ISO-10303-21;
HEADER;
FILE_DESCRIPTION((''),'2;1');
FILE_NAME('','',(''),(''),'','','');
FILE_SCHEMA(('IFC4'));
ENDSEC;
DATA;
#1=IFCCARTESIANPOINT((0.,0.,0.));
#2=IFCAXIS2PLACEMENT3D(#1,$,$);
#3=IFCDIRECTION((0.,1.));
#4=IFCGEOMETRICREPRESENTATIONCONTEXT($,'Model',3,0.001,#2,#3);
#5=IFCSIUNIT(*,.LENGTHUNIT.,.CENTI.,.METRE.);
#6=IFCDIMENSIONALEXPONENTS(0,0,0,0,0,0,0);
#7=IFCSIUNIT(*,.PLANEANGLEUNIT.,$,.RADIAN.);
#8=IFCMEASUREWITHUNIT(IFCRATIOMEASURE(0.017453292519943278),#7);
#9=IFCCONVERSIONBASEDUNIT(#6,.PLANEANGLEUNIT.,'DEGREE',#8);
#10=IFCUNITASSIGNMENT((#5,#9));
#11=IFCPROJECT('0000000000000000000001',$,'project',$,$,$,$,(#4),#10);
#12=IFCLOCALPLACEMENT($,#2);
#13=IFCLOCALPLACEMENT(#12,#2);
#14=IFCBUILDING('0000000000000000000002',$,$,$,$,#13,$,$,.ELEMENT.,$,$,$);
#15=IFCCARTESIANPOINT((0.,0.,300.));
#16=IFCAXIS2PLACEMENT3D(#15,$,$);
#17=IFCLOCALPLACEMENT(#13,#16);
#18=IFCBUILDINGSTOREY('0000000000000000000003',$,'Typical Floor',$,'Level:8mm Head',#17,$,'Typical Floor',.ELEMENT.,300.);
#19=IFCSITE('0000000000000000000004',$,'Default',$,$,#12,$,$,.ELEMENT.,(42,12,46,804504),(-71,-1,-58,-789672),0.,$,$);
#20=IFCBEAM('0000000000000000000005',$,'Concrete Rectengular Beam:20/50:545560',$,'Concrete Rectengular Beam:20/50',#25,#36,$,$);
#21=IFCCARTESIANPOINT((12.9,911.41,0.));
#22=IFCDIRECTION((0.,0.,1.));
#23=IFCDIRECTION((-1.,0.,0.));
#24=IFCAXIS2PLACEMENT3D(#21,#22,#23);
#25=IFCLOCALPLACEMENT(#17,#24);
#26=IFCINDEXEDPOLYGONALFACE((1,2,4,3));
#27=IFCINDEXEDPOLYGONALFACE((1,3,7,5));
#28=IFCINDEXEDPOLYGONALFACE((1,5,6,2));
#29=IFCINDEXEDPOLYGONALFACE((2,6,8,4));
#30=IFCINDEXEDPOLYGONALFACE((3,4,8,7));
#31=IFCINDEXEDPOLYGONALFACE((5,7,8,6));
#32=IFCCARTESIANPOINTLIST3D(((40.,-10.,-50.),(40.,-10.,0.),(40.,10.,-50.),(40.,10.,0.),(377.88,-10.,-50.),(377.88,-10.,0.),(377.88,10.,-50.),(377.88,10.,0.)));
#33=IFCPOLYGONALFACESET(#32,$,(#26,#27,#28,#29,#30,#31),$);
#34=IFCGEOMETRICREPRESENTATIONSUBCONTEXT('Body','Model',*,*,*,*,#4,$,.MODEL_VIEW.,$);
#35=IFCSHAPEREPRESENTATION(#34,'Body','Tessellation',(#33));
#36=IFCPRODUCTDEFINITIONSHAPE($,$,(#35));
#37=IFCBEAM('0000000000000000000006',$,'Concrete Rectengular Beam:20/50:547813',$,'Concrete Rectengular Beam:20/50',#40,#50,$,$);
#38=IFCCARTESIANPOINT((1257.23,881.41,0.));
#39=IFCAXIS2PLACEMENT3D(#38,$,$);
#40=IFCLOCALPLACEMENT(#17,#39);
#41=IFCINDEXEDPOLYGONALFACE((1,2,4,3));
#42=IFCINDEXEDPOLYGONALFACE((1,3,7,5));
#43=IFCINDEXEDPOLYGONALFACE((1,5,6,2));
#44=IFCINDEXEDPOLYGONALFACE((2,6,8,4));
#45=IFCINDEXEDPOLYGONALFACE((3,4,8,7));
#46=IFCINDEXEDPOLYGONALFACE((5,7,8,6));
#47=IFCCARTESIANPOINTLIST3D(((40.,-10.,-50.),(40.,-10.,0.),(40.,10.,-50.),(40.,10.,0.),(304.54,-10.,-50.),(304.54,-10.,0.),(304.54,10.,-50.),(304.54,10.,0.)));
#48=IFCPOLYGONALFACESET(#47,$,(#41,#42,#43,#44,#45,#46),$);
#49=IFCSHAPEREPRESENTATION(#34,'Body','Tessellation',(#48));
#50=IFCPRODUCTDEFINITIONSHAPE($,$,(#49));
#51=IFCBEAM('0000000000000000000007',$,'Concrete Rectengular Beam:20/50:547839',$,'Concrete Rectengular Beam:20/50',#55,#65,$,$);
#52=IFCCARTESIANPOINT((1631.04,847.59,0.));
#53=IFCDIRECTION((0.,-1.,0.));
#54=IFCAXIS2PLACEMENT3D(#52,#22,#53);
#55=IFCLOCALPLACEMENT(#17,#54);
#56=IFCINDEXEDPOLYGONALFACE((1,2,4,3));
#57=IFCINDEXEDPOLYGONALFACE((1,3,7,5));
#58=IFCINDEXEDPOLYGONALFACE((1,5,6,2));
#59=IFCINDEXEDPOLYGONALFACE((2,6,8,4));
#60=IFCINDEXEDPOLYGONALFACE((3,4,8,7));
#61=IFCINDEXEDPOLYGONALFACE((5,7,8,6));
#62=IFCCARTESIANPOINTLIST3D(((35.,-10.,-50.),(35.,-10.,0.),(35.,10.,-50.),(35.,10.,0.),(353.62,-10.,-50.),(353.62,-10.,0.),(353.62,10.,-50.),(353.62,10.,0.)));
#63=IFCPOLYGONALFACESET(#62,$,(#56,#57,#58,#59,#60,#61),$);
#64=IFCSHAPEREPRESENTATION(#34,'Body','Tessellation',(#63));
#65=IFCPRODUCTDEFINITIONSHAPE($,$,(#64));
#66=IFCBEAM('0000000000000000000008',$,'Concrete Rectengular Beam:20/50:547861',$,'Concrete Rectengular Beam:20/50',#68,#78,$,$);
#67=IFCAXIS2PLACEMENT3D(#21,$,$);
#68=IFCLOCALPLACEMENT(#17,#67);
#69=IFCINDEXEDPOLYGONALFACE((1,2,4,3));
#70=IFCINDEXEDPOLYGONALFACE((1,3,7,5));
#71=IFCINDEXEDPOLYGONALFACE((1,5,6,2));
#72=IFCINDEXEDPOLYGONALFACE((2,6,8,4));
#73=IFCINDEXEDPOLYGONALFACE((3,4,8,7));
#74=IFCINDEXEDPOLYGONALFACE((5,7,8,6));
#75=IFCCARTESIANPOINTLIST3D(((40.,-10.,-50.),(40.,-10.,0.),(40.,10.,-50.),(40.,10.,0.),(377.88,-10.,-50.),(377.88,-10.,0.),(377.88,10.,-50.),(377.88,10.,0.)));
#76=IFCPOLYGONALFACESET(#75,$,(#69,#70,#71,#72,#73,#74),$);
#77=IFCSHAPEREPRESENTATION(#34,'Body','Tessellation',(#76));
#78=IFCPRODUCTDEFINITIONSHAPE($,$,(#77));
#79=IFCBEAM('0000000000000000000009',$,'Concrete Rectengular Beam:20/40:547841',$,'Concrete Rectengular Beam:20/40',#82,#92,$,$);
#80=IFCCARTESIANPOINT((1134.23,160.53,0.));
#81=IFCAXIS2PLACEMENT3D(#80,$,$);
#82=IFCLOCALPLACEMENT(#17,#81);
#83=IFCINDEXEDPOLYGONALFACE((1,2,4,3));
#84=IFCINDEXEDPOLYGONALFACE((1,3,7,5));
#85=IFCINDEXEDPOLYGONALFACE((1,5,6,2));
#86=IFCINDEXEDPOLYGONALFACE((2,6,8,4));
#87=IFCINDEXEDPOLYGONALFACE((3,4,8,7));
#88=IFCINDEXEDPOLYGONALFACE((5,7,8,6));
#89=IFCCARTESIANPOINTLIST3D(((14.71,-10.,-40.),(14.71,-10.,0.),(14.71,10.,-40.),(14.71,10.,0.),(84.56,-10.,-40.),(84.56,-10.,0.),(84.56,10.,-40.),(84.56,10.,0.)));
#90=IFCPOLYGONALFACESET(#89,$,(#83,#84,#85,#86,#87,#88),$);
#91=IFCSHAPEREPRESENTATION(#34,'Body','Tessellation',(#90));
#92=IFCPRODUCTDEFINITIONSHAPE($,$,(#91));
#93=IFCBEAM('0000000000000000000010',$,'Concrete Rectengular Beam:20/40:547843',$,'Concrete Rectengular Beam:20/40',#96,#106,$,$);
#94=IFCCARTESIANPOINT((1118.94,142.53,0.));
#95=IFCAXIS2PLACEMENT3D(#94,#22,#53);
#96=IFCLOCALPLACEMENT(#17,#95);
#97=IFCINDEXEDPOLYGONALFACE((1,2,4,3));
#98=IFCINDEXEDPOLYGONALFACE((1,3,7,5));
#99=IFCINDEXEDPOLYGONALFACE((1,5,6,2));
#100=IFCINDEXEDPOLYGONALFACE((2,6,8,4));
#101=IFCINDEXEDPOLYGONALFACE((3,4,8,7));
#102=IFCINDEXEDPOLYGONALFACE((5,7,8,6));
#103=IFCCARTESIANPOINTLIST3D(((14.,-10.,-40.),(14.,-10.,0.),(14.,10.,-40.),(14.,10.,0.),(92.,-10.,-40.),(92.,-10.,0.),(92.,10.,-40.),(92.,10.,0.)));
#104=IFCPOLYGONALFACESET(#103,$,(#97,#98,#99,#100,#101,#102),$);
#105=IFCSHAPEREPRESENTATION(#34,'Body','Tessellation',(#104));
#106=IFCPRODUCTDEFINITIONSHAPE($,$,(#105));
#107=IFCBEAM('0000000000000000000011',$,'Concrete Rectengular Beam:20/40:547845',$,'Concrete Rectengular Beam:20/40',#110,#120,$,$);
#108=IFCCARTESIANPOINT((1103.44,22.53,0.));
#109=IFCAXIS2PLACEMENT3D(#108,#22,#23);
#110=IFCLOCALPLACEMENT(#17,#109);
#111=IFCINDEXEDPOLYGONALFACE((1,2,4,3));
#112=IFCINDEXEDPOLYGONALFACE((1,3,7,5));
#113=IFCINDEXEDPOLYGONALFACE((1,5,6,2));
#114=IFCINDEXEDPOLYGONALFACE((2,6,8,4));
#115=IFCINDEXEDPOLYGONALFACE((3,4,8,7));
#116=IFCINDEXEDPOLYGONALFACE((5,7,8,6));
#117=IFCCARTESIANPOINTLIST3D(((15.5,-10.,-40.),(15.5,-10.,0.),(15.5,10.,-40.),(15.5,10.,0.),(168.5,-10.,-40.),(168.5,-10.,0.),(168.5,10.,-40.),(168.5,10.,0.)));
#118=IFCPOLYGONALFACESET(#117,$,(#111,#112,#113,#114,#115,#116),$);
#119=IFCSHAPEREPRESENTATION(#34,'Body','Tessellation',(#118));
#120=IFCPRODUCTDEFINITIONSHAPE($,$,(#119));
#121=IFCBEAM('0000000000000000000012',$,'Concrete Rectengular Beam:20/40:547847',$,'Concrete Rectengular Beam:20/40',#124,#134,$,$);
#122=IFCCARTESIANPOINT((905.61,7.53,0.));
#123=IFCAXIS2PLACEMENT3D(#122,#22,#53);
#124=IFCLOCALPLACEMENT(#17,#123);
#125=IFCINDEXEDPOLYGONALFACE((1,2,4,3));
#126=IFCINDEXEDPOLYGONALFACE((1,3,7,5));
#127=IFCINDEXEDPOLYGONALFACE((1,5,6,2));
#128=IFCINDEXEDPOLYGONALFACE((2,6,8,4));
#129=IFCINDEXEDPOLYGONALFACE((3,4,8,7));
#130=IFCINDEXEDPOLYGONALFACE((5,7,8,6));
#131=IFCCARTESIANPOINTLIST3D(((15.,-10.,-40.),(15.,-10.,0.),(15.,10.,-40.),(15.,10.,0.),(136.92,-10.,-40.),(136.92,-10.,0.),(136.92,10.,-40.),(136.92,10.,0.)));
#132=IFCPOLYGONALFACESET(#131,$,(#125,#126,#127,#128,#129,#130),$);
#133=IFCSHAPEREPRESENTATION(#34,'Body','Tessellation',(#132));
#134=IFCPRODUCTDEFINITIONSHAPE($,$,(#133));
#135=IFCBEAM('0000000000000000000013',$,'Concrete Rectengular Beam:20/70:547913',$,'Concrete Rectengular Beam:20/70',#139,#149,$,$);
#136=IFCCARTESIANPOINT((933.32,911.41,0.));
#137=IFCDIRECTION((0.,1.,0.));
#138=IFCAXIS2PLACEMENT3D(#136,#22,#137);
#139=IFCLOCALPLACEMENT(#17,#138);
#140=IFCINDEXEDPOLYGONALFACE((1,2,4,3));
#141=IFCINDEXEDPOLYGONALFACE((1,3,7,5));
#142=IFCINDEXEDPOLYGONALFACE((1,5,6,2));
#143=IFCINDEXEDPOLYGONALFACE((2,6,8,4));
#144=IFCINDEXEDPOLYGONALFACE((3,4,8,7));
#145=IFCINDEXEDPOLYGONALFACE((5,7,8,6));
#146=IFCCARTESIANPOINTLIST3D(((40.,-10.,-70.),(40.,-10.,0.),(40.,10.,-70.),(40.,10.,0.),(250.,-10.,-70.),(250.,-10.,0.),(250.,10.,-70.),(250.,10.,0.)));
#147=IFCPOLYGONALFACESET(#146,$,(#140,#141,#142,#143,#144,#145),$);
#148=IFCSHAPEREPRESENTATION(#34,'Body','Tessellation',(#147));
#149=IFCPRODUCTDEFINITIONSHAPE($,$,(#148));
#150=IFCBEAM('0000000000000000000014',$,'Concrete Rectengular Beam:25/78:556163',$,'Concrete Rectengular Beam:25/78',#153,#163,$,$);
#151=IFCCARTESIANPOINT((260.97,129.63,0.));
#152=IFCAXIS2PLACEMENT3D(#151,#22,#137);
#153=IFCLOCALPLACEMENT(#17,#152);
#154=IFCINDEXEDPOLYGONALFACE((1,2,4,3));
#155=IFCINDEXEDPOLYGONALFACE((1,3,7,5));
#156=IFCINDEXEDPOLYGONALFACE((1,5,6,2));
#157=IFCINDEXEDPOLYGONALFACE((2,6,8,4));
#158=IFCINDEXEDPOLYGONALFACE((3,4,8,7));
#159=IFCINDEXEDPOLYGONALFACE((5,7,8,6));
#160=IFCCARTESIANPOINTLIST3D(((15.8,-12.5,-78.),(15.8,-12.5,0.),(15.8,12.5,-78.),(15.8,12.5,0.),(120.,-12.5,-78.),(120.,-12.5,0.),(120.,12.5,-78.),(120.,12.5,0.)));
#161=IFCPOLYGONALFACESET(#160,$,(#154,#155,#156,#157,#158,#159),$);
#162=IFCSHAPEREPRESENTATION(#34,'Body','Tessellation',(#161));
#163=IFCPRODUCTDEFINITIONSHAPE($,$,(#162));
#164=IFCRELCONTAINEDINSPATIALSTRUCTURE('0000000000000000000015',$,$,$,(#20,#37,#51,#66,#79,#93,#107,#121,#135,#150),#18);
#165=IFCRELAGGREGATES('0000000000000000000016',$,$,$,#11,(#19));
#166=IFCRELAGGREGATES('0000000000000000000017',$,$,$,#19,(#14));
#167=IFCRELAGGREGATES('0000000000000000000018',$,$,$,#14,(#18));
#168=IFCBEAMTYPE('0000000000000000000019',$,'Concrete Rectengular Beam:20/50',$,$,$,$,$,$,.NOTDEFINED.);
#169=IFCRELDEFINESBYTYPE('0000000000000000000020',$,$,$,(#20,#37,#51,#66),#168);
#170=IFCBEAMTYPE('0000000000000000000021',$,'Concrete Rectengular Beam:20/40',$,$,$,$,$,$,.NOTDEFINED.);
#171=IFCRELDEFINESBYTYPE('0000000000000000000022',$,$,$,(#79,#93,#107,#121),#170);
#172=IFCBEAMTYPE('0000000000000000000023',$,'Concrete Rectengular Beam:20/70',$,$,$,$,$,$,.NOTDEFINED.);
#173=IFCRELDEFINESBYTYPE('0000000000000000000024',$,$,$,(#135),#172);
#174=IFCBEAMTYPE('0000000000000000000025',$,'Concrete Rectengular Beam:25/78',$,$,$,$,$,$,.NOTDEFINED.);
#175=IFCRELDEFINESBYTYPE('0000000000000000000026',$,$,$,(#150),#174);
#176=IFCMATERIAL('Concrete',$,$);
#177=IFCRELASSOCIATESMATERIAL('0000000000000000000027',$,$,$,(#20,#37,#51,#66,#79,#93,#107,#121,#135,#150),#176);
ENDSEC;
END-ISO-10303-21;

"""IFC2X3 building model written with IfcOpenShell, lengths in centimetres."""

from ifc_helpers import new_model, entity, si_unit, converted_unit, direction, frame, frame_2d, origin, origin_2d_with_axis, place, context, subcontext, project, spatial, rectangle, extrude, material, type_object, element, save


model = new_model("IFC2X3")

# Units and contexts
model_context = context("Model", 3, precision=0.001, world=origin(), true_north=direction((0.0, 1.0)))
body_context = subcontext(model_context, "Body", "Model", "MODEL_VIEW")
ifc_project = project(units=[si_unit("LENGTHUNIT", "METRE", prefix="CENTI"), converted_unit("PLANEANGLEUNIT", "DEGREE", entity("IfcRatioMeasure", 0.017453292519943278), si_unit("PLANEANGLEUNIT", "RADIAN"), dimensions=[0, 0, 0, 0, 0, 0, 0])], contexts=[model_context])

# Site, building, storey
site_placement = place(None, origin())
site = spatial("IfcSite", under=ifc_project, at=site_placement, Name="Default", CompositionType="ELEMENT", RefLatitude=(42, 12, 46, 804504), RefLongitude=(-71, -1, -58, -789672), RefElevation=0.0)
building_placement = place(site_placement, origin())
building = spatial("IfcBuilding", under=site, at=building_placement, CompositionType="ELEMENT")
storey_placement = place(building_placement, frame((0.0, 0.0, 300.0)))
storey = spatial("IfcBuildingStorey", under=building, at=storey_placement, Name="Typical Floor", ObjectType="Level:8mm Head", LongName="Typical Floor", CompositionType="ELEMENT", Elevation=300.0)

# Beams
ifc_material = material(Name="Concrete")
beam_type_1 = type_object("IfcBeamType", Name="Concrete Rectengular Beam:20/50", PredefinedType="NOTDEFINED")
beam_1_placement = place(storey_placement, frame((12.9, 911.41, 0.0), z_axis=(0.0, 0.0, 1.0), x_axis=(-1.0, 0.0, 0.0)))
element("IfcBeam", 1, at=beam_1_placement, inside=storey, type_object=beam_type_1, material=ifc_material, Name="Concrete Rectengular Beam:20/50:545560", ObjectType="Concrete Rectengular Beam:20/50", context=body_context, shape_type="SweptSolid", body=[
    extrude(rectangle(XDim=50.0, YDim=20.0, at=frame_2d((0.0, 0.0), x_axis=(1.0, 0.0))), frame((40.0, 0.0, -25.0), z_axis=(1.0, 0.0, 0.0), x_axis=(0.0, 0.0, -1.0)), (0.0, 0.0, 1.0), 337.88),
])
beam_2_placement = place(storey_placement, frame((1257.23, 881.41, 0.0)))
element("IfcBeam", 2, at=beam_2_placement, inside=storey, type_object=beam_type_1, material=ifc_material, Name="Concrete Rectengular Beam:20/50:547813", ObjectType="Concrete Rectengular Beam:20/50", context=body_context, shape_type="SweptSolid", body=[
    extrude(rectangle(XDim=50.0, YDim=20.0, at=frame_2d((0.0, 0.0), x_axis=(1.0, 0.0))), frame((40.0, 0.0, -25.0), z_axis=(1.0, 0.0, 0.0), x_axis=(0.0, 0.0, -1.0)), (0.0, 0.0, 1.0), 264.54),
])
beam_3_placement = place(storey_placement, frame((1631.04, 847.59, 0.0), z_axis=(0.0, 0.0, 1.0), x_axis=(0.0, -1.0, 0.0)))
element("IfcBeam", 3, at=beam_3_placement, inside=storey, type_object=beam_type_1, material=ifc_material, Name="Concrete Rectengular Beam:20/50:547839", ObjectType="Concrete Rectengular Beam:20/50", context=body_context, shape_type="SweptSolid", body=[
    extrude(rectangle(XDim=50.0, YDim=20.0, at=frame_2d((0.0, 0.0), x_axis=(1.0, 0.0))), frame((35.0, 0.0, -25.0), z_axis=(1.0, 0.0, 0.0), x_axis=(0.0, 0.0, -1.0)), (0.0, 0.0, 1.0), 318.62),
])
beam_4_placement = place(storey_placement, frame((12.9, 911.41, 0.0)))
element("IfcBeam", 4, at=beam_4_placement, inside=storey, type_object=beam_type_1, material=ifc_material, Name="Concrete Rectengular Beam:20/50:547861", ObjectType="Concrete Rectengular Beam:20/50", context=body_context, shape_type="SweptSolid", body=[
    extrude(rectangle(XDim=50.0, YDim=20.0, at=frame_2d((0.0, 0.0), x_axis=(1.0, 0.0))), frame((40.0, 0.0, -25.0), z_axis=(1.0, 0.0, 0.0), x_axis=(0.0, 0.0, -1.0)), (0.0, 0.0, 1.0), 337.88),
])
beam_type_2 = type_object("IfcBeamType", Name="Concrete Rectengular Beam:20/40", PredefinedType="NOTDEFINED")
beam_5_placement = place(storey_placement, frame((1134.23, 160.53, 0.0)))
element("IfcBeam", 5, at=beam_5_placement, inside=storey, type_object=beam_type_2, material=ifc_material, Name="Concrete Rectengular Beam:20/40:547841", ObjectType="Concrete Rectengular Beam:20/40", context=body_context, shape_type="SweptSolid", body=[
    extrude(rectangle(XDim=40.0, YDim=20.0, at=frame_2d((0.0, 0.0), x_axis=(1.0, 0.0))), frame((14.71, 0.0, -20.0), z_axis=(1.0, 0.0, 0.0), x_axis=(0.0, 0.0, -1.0)), (0.0, 0.0, 1.0), 69.85),
])
beam_6_placement = place(storey_placement, frame((1118.94, 142.53, 0.0), z_axis=(0.0, 0.0, 1.0), x_axis=(0.0, -1.0, 0.0)))
element("IfcBeam", 6, at=beam_6_placement, inside=storey, type_object=beam_type_2, material=ifc_material, Name="Concrete Rectengular Beam:20/40:547843", ObjectType="Concrete Rectengular Beam:20/40", context=body_context, shape_type="SweptSolid", body=[
    extrude(rectangle(XDim=40.0, YDim=20.0, at=origin_2d_with_axis()), frame((14.0, 0.0, -20.0), z_axis=(1.0, 0.0, 0.0), x_axis=(0.0, 0.0, -1.0)), (0.0, 0.0, 1.0), 78.0),
])
beam_7_placement = place(storey_placement, frame((1103.44, 22.53, 0.0), z_axis=(0.0, 0.0, 1.0), x_axis=(-1.0, 0.0, 0.0)))
element("IfcBeam", 7, at=beam_7_placement, inside=storey, type_object=beam_type_2, material=ifc_material, Name="Concrete Rectengular Beam:20/40:547845", ObjectType="Concrete Rectengular Beam:20/40", context=body_context, shape_type="SweptSolid", body=[
    extrude(rectangle(XDim=40.0, YDim=20.0, at=frame_2d((0.0, 0.0), x_axis=(1.0, 0.0))), frame((15.5, 0.0, -20.0), z_axis=(1.0, 0.0, 0.0), x_axis=(0.0, 0.0, -1.0)), (0.0, 0.0, 1.0), 153.0),
])
beam_8_placement = place(storey_placement, frame((905.61, 7.53, 0.0), z_axis=(0.0, 0.0, 1.0), x_axis=(0.0, -1.0, 0.0)))
element("IfcBeam", 8, at=beam_8_placement, inside=storey, type_object=beam_type_2, material=ifc_material, Name="Concrete Rectengular Beam:20/40:547847", ObjectType="Concrete Rectengular Beam:20/40", context=body_context, shape_type="SweptSolid", body=[
    extrude(rectangle(XDim=40.0, YDim=20.0, at=frame_2d((0.0, 0.0), x_axis=(1.0, 0.0))), frame((15.0, 0.0, -20.0), z_axis=(1.0, 0.0, 0.0), x_axis=(0.0, 0.0, -1.0)), (0.0, 0.0, 1.0), 121.92),
])
beam_type_3 = type_object("IfcBeamType", Name="Concrete Rectengular Beam:20/70", PredefinedType="NOTDEFINED")
beam_9_placement = place(storey_placement, frame((933.32, 911.41, 0.0), z_axis=(0.0, 0.0, 1.0), x_axis=(0.0, 1.0, 0.0)))
element("IfcBeam", 9, at=beam_9_placement, inside=storey, type_object=beam_type_3, material=ifc_material, Name="Concrete Rectengular Beam:20/70:547913", ObjectType="Concrete Rectengular Beam:20/70", context=body_context, shape_type="SweptSolid", body=[
    extrude(rectangle(XDim=70.0, YDim=20.0, at=frame_2d((0.0, 0.0), x_axis=(1.0, 0.0))), frame((40.0, 0.0, -35.0), z_axis=(1.0, 0.0, 0.0), x_axis=(0.0, 0.0, -1.0)), (0.0, 0.0, 1.0), 210.0),
])
beam_type_4 = type_object("IfcBeamType", Name="Concrete Rectengular Beam:25/78", PredefinedType="NOTDEFINED")
beam_10_placement = place(storey_placement, frame((260.97, 129.63, 0.0), z_axis=(0.0, 0.0, 1.0), x_axis=(0.0, 1.0, 0.0)))
element("IfcBeam", 10, at=beam_10_placement, inside=storey, type_object=beam_type_4, material=ifc_material, Name="Concrete Rectengular Beam:25/78:556163", ObjectType="Concrete Rectengular Beam:25/78", context=body_context, shape_type="SweptSolid", body=[
    extrude(rectangle(XDim=78.0, YDim=25.0, at=frame_2d((0.0, 0.0), x_axis=(1.0, 0.0))), frame((15.8, 0.0, -39.0), z_axis=(1.0, 0.0, 0.0), x_axis=(0.0, 0.0, -1.0)), (0.0, 0.0, 1.0), 104.2),
])

save(model, "model.ifc")
